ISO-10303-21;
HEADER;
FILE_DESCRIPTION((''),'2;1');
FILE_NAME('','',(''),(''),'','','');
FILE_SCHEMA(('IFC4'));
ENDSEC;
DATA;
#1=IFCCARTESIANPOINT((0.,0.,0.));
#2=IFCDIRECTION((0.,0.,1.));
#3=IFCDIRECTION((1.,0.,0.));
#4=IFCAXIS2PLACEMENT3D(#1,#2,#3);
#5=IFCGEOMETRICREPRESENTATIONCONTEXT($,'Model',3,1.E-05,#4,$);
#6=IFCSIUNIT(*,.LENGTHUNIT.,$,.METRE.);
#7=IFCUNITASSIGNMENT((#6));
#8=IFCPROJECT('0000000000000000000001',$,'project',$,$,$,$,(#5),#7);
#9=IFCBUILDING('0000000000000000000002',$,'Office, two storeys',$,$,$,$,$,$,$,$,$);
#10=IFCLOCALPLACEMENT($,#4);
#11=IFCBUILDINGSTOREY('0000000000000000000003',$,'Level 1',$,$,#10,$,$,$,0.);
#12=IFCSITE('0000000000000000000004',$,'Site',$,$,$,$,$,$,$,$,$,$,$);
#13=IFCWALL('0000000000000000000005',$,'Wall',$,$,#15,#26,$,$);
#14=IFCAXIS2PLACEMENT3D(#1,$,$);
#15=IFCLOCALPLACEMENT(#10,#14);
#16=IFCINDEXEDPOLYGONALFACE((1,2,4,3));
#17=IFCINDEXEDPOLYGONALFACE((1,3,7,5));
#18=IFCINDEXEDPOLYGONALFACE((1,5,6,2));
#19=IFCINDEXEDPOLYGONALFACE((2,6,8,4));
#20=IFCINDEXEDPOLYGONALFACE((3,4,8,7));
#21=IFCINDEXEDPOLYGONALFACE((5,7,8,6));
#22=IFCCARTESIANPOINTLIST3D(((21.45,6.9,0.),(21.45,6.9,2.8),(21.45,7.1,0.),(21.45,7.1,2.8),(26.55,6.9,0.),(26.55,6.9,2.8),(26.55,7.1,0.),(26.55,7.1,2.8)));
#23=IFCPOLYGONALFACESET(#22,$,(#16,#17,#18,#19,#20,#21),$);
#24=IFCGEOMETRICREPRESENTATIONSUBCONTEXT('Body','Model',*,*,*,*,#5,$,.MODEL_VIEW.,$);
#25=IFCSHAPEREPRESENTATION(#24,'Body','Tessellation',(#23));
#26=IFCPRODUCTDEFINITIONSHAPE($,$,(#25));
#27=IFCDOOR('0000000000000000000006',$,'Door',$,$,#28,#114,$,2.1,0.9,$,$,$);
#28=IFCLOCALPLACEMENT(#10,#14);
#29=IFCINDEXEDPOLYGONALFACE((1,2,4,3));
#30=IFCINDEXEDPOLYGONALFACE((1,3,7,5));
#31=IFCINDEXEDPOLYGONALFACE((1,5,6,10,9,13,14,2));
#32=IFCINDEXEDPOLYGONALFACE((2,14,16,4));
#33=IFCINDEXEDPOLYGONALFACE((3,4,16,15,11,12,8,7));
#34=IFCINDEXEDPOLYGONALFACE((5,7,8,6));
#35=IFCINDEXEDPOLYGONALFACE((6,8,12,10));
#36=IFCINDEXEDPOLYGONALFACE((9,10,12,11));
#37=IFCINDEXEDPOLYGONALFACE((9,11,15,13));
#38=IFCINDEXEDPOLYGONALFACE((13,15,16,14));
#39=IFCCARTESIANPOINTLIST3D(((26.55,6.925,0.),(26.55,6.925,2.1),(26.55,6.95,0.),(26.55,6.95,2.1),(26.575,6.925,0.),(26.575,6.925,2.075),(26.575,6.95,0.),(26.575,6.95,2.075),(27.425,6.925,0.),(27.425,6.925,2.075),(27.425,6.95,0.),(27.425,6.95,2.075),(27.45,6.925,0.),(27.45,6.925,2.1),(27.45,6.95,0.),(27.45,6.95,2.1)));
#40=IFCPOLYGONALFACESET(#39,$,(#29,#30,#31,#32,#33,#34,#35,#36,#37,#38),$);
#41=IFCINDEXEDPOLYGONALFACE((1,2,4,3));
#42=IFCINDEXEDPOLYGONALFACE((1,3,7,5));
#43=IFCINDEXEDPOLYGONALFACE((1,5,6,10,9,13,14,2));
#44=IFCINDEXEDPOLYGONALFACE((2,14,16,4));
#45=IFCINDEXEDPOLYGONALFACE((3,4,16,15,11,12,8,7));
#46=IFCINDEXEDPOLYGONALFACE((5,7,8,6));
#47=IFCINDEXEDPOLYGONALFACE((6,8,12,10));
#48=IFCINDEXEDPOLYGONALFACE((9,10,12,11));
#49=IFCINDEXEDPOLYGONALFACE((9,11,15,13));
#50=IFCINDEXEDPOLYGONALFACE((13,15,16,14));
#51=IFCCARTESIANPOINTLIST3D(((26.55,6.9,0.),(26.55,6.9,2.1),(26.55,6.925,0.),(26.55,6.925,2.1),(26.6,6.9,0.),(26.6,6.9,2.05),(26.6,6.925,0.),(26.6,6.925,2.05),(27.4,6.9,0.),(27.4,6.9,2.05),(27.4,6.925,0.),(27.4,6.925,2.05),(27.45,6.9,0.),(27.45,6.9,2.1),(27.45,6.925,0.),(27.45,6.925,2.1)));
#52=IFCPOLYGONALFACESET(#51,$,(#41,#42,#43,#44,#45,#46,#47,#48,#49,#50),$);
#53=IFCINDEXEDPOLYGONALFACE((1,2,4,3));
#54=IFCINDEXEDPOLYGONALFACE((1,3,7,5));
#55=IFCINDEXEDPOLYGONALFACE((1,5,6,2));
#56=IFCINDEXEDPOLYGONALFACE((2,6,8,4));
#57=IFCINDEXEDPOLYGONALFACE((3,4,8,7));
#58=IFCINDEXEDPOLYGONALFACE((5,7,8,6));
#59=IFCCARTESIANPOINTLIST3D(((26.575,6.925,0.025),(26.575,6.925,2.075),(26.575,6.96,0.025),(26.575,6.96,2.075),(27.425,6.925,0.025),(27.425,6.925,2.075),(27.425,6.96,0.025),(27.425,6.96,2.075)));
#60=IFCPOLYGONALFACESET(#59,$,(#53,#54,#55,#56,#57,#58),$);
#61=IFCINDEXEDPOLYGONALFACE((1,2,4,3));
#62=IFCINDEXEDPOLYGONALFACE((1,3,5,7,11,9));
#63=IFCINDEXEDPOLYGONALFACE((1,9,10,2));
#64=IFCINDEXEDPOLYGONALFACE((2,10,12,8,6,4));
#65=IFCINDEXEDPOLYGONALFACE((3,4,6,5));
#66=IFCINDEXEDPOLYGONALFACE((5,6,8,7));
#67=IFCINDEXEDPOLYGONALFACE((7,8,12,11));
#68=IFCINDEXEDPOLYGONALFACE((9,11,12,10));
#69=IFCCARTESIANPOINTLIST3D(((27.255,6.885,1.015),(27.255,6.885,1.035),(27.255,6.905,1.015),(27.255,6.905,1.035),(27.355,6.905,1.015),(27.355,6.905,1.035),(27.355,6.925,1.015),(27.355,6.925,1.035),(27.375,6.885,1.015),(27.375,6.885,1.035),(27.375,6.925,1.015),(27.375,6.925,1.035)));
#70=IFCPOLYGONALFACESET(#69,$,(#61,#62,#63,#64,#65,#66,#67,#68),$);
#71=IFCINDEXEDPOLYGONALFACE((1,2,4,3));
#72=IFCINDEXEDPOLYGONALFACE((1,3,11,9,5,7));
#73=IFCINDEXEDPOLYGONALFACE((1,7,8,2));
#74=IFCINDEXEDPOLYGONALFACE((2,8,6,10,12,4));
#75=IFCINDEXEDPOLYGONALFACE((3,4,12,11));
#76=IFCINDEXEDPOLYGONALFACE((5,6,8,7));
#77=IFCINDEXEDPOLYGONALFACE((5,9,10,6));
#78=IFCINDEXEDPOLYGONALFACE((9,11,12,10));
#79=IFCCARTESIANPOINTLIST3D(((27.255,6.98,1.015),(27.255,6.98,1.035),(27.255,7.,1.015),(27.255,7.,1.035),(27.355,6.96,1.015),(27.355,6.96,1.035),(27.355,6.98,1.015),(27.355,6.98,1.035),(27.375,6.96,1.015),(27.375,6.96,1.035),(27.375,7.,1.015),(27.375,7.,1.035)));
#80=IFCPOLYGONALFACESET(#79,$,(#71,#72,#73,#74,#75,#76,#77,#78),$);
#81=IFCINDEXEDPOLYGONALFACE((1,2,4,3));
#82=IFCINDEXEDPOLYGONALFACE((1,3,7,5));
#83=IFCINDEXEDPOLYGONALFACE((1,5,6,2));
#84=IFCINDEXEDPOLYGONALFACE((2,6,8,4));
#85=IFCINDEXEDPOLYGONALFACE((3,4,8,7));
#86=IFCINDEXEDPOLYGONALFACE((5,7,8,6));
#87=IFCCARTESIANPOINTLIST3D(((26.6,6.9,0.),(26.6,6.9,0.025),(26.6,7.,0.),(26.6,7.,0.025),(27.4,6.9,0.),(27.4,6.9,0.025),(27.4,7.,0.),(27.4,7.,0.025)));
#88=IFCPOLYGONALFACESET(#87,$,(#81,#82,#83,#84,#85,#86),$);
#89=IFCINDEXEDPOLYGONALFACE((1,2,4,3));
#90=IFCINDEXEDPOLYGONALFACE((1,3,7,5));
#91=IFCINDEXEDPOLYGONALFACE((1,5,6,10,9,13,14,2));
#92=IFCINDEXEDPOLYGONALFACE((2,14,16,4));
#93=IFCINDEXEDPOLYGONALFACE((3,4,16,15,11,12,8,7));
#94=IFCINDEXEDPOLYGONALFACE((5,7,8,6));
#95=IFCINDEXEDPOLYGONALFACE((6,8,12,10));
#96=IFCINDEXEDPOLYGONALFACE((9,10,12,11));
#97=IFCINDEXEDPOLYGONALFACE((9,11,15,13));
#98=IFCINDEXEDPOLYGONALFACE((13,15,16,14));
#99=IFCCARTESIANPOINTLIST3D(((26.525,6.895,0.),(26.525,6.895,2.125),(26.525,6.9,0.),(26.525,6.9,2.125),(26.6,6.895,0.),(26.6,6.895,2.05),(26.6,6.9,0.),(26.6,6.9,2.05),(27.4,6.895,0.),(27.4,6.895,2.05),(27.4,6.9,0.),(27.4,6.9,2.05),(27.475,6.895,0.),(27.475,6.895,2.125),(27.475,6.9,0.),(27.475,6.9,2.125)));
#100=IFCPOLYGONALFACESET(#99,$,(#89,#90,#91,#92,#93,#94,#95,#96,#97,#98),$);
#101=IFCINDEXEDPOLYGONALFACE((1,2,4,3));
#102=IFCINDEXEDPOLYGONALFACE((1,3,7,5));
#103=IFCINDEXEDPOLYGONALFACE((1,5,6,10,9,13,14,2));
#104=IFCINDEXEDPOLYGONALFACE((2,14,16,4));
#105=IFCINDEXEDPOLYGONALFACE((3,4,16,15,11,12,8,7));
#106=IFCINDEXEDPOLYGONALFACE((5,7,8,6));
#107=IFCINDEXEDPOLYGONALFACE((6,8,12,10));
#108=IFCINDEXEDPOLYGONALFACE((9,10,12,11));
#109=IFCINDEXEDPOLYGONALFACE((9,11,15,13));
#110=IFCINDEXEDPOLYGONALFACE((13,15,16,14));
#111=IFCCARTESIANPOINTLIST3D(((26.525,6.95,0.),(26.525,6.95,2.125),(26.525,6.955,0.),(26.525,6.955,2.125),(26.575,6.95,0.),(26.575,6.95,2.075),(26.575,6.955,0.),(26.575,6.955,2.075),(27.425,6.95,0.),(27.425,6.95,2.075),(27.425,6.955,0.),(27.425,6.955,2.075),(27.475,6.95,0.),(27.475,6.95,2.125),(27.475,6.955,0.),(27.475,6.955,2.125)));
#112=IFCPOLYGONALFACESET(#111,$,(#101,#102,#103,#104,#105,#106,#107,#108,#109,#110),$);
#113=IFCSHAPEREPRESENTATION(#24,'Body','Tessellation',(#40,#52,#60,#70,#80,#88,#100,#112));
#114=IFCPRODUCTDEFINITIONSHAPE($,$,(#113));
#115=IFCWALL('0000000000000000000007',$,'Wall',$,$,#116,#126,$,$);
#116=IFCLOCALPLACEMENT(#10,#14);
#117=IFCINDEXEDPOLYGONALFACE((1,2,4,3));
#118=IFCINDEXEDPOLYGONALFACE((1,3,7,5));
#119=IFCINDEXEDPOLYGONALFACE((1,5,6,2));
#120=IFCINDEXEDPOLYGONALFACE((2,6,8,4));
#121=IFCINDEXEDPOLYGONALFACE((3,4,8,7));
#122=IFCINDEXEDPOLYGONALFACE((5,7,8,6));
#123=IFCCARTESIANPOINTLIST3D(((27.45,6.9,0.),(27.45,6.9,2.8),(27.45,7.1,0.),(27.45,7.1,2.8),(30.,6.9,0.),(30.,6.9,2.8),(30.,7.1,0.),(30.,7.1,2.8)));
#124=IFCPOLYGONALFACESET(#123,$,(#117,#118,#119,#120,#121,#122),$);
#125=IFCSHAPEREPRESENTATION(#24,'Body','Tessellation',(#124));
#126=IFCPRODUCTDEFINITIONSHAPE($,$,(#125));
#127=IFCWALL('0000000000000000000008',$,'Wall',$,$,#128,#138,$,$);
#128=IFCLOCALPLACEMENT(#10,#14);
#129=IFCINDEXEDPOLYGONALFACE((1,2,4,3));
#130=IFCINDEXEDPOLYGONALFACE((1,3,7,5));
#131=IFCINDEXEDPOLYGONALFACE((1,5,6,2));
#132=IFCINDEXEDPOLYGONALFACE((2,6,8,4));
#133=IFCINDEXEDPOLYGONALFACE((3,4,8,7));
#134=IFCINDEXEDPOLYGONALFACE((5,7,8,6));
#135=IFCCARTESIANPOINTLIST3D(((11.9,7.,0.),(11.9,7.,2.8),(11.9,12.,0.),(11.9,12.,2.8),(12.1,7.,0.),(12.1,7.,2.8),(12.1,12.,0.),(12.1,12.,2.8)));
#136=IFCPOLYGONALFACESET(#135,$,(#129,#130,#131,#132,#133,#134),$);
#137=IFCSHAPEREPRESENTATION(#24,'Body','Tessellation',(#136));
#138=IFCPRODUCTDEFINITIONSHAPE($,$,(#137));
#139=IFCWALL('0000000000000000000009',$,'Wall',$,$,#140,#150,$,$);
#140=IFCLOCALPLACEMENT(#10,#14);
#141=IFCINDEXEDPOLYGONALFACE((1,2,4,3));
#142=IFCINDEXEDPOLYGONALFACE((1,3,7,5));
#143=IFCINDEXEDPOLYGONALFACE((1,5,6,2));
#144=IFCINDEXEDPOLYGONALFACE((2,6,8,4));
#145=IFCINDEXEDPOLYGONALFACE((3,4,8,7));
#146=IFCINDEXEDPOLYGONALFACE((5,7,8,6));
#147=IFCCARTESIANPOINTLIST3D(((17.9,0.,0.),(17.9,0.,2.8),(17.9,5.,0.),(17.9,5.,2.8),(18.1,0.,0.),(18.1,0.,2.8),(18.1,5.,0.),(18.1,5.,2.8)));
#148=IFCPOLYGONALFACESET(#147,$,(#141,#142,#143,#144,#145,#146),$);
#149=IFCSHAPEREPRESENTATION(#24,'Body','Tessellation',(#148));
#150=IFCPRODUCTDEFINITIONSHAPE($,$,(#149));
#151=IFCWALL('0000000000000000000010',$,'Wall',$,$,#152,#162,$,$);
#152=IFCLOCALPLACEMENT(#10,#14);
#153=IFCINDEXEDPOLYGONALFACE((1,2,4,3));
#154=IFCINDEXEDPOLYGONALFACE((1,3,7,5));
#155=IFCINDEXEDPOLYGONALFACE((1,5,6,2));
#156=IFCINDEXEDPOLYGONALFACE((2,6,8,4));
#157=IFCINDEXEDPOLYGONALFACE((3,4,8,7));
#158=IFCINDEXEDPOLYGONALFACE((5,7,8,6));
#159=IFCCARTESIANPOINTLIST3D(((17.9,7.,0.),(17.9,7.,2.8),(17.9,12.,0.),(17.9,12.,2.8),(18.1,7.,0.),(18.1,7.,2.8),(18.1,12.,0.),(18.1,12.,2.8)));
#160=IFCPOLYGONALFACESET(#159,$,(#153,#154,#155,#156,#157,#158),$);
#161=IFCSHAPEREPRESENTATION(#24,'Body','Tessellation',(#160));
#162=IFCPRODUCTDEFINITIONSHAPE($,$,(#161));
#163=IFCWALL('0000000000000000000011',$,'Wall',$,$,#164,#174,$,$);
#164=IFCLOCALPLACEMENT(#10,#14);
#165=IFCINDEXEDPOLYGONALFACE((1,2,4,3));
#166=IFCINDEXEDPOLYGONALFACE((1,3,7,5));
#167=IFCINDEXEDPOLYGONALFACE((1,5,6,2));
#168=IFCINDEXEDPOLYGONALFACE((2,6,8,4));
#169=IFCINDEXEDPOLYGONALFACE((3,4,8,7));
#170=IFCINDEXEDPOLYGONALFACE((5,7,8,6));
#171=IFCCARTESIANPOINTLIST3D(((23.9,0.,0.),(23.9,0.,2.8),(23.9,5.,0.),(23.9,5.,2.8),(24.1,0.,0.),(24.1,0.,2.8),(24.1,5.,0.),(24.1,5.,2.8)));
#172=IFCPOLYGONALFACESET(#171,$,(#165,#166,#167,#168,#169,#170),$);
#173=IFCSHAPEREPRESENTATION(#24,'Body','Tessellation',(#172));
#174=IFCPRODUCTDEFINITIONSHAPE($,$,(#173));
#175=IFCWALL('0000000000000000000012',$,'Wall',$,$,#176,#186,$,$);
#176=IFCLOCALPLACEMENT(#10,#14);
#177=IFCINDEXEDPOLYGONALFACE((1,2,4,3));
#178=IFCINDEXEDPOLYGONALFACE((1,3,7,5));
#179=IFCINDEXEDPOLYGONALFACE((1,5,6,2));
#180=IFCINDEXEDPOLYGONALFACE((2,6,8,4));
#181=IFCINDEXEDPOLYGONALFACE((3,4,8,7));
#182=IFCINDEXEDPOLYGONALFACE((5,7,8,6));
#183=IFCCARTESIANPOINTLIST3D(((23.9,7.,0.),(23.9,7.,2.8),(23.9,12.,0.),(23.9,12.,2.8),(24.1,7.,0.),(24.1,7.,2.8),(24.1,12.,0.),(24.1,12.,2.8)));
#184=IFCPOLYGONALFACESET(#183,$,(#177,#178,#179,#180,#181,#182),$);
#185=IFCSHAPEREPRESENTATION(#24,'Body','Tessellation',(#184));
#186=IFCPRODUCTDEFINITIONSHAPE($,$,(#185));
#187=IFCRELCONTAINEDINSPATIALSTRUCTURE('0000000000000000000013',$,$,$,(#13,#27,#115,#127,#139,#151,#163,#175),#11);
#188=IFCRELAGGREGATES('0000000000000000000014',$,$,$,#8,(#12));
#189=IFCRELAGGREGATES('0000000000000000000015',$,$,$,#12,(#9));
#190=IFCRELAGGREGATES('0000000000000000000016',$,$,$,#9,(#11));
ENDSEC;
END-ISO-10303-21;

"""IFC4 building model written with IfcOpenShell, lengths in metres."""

from ifc_helpers import new_model, si_unit, frame, origin_with_axes, place, context, subcontext, project, spatial, line, indexed_curve, outline, extrude, element, save


model = new_model("IFC4")

# Units and contexts
model_context = context("Model", 3, precision=1e-05, world=origin_with_axes())
body_context = subcontext(model_context, "Body", "Model", "MODEL_VIEW")
ifc_project = project(units=[si_unit("LENGTHUNIT", "METRE")], contexts=[model_context])

# Site, building, storey
site = spatial("IfcSite", under=ifc_project, Name="Site")
building = spatial("IfcBuilding", under=site, Name="Office, two storeys")
storey_placement = place(None, origin_with_axes())
storey = spatial("IfcBuildingStorey", under=building, at=storey_placement, Name="Level 1", Elevation=0.0)

# Wall
wall_1_placement = place(storey_placement, frame((21.45, 7.0, 0.0), z_axis=(0.0, 0.0, 1.0), x_axis=(1.0, 0.0, 0.0)))
element("IfcWall", 1, at=wall_1_placement, inside=storey, Name="Wall", context=body_context, shape_type="SweptSolid", body=[
    extrude(outline(indexed_curve([(0.0, 0.0), (0.0, 0.2), (5.1, 0.2), (5.1, 0.0), (0.0, 0.0)], self_intersect=False)), frame((0.0, -0.1, 0.0), z_axis=(0.0, 0.0, 1.0), x_axis=(1.0, 0.0, 0.0)), (0.0, 0.0, 1.0), 2.8),
])

# Door
door_1_placement = place(storey_placement, frame((26.55, 6.9, 0.0), z_axis=(0.0, 0.0, 1.0), x_axis=(1.0, 0.0, 0.0)))
element("IfcDoor", 2, at=door_1_placement, inside=storey, Name="Door", OverallHeight=2.1, OverallWidth=0.9, context=body_context, shape_type="SweptSolid", body=[
    extrude(outline(indexed_curve([(0.0, 0.0), (0.0, 2.1), (0.9, 2.1), (0.9, 0.0), (0.875, 0.0), (0.875, 2.075), (0.025, 2.075), (0.025, 0.0)], segments=[line(1, 2, 3, 4, 5, 6, 7, 8, 1)])), frame((0.0, 0.025, 0.0), z_axis=(0.0, -1.0, 0.0), x_axis=(1.0, 0.0, 0.0)), (0.0, 0.0, -1.0), 0.025),
    extrude(outline(indexed_curve([(0.0, 0.0), (0.0, 2.1), (0.9, 2.1), (0.9, 0.0), (0.85, 0.0), (0.85, 2.05), (0.05, 2.05), (0.05, 0.0)], segments=[line(1, 2, 3, 4, 5, 6, 7, 8, 1)])), frame((0.0, 0.0, 0.0), z_axis=(0.0, -1.0, 0.0), x_axis=(1.0, 0.0, 0.0)), (0.0, 0.0, -1.0), 0.025),
    extrude(outline(indexed_curve([(0.0, 0.0), (0.85, 0.0), (0.85, 0.035), (0.0, 0.035)], segments=[line(1, 2, 3, 4, 1)])), frame((0.025, 0.025, 0.025), z_axis=(0.0, 0.0, 1.0), x_axis=(1.0, 0.0, 0.0)), (0.0, 0.0, 1.0), 2.05),
    extrude(outline(indexed_curve([(0.0, 0.0), (0.0, -0.04), (-0.12, -0.04), (-0.12, -0.02), (-0.02, -0.02), (-0.02, 0.0)], segments=[line(1, 2, 3, 4, 5, 6, 1)])), frame((0.825, 0.025, 1.015), z_axis=(0.0, 0.0, 1.0), x_axis=(1.0, 0.0, 0.0)), (0.0, 0.0, 1.0), 0.02),
    extrude(outline(indexed_curve([(0.0, 0.0), (0.0, 0.04), (-0.12, 0.04), (-0.12, 0.02), (-0.02, 0.02), (-0.02, 0.0)], segments=[line(1, 2, 3, 4, 5, 6, 1)])), frame((0.825, 0.06, 1.015), z_axis=(0.0, 0.0, 1.0), x_axis=(1.0, 0.0, 0.0)), (0.0, 0.0, 1.0), 0.02),
    extrude(outline(indexed_curve([(0.0, 0.0), (0.8, 0.0), (0.8, 0.1), (0.0, 0.1)], segments=[line(1, 2, 3, 4, 1)])), frame((0.05, 0.0, 0.0), z_axis=(0.0, 0.0, 1.0), x_axis=(1.0, 0.0, 0.0)), (0.0, 0.0, 1.0), 0.025),
    extrude(outline(indexed_curve([(0.0, 0.0), (0.0, 2.125), (0.95, 2.125), (0.95, 0.0), (0.875, 0.0), (0.875, 2.05), (0.075, 2.05), (0.075, 0.0)], segments=[line(1, 2, 3, 4, 5, 6, 7, 8, 1)])), frame((-0.025, -0.005, 0.0), z_axis=(0.0, -1.0, 0.0), x_axis=(1.0, 0.0, 0.0)), (0.0, 0.0, -1.0), 0.005),
    extrude(outline(indexed_curve([(0.0, 0.0), (0.0, 2.125), (0.95, 2.125), (0.95, 0.0), (0.9, 0.0), (0.9, 2.075), (0.05, 2.075), (0.05, 0.0)], segments=[line(1, 2, 3, 4, 5, 6, 7, 8, 1)])), frame((-0.025, 0.05, 0.0), z_axis=(0.0, -1.0, 0.0), x_axis=(1.0, 0.0, 0.0)), (0.0, 0.0, -1.0), 0.005),
])

# Walls
wall_2_placement = place(storey_placement, frame((27.45, 7.0, 0.0), z_axis=(0.0, 0.0, 1.0), x_axis=(1.0, 0.0, 0.0)))
element("IfcWall", 3, at=wall_2_placement, inside=storey, Name="Wall", context=body_context, shape_type="SweptSolid", body=[
    extrude(outline(indexed_curve([(0.0, 0.0), (0.0, 0.2), (2.55, 0.2), (2.55, 0.0), (0.0, 0.0)], self_intersect=False)), frame((0.0, -0.1, 0.0), z_axis=(0.0, 0.0, 1.0), x_axis=(1.0, 0.0, 0.0)), (0.0, 0.0, 1.0), 2.8),
])
for number, where, z_axis, x_axis, name in (
    (4, (12.0, 7.0, 0.0), (0.0, 0.0, 1.0), (0.0, 1.0, 0.0), "Wall"),
    (5, (18.0, 0.0, 0.0), (0.0, 0.0, 1.0), (0.0, 1.0, 0.0), "Wall"),
    (6, (18.0, 7.0, 0.0), (0.0, 0.0, 1.0), (0.0, 1.0, 0.0), "Wall"),
    (7, (24.0, 0.0, 0.0), (0.0, 0.0, 1.0), (0.0, 1.0, 0.0), "Wall"),
    (8, (24.0, 7.0, 0.0), (0.0, 0.0, 1.0), (0.0, 1.0, 0.0), "Wall"),
):
    element("IfcWall", number, at=place(storey_placement, frame(where, z_axis=z_axis, x_axis=x_axis)), inside=storey, Name=name, context=body_context, shape_type="SweptSolid", body=[
        extrude(outline(indexed_curve([(0.0, 0.0), (0.0, 0.2), (5.0, 0.2), (5.0, 0.0), (0.0, 0.0)], self_intersect=False)), frame((0.0, -0.1, 0.0), z_axis=(0.0, 0.0, 1.0), x_axis=(1.0, 0.0, 0.0)), (0.0, 0.0, 1.0), 2.8),
    ])

save(model, "model.ifc")
